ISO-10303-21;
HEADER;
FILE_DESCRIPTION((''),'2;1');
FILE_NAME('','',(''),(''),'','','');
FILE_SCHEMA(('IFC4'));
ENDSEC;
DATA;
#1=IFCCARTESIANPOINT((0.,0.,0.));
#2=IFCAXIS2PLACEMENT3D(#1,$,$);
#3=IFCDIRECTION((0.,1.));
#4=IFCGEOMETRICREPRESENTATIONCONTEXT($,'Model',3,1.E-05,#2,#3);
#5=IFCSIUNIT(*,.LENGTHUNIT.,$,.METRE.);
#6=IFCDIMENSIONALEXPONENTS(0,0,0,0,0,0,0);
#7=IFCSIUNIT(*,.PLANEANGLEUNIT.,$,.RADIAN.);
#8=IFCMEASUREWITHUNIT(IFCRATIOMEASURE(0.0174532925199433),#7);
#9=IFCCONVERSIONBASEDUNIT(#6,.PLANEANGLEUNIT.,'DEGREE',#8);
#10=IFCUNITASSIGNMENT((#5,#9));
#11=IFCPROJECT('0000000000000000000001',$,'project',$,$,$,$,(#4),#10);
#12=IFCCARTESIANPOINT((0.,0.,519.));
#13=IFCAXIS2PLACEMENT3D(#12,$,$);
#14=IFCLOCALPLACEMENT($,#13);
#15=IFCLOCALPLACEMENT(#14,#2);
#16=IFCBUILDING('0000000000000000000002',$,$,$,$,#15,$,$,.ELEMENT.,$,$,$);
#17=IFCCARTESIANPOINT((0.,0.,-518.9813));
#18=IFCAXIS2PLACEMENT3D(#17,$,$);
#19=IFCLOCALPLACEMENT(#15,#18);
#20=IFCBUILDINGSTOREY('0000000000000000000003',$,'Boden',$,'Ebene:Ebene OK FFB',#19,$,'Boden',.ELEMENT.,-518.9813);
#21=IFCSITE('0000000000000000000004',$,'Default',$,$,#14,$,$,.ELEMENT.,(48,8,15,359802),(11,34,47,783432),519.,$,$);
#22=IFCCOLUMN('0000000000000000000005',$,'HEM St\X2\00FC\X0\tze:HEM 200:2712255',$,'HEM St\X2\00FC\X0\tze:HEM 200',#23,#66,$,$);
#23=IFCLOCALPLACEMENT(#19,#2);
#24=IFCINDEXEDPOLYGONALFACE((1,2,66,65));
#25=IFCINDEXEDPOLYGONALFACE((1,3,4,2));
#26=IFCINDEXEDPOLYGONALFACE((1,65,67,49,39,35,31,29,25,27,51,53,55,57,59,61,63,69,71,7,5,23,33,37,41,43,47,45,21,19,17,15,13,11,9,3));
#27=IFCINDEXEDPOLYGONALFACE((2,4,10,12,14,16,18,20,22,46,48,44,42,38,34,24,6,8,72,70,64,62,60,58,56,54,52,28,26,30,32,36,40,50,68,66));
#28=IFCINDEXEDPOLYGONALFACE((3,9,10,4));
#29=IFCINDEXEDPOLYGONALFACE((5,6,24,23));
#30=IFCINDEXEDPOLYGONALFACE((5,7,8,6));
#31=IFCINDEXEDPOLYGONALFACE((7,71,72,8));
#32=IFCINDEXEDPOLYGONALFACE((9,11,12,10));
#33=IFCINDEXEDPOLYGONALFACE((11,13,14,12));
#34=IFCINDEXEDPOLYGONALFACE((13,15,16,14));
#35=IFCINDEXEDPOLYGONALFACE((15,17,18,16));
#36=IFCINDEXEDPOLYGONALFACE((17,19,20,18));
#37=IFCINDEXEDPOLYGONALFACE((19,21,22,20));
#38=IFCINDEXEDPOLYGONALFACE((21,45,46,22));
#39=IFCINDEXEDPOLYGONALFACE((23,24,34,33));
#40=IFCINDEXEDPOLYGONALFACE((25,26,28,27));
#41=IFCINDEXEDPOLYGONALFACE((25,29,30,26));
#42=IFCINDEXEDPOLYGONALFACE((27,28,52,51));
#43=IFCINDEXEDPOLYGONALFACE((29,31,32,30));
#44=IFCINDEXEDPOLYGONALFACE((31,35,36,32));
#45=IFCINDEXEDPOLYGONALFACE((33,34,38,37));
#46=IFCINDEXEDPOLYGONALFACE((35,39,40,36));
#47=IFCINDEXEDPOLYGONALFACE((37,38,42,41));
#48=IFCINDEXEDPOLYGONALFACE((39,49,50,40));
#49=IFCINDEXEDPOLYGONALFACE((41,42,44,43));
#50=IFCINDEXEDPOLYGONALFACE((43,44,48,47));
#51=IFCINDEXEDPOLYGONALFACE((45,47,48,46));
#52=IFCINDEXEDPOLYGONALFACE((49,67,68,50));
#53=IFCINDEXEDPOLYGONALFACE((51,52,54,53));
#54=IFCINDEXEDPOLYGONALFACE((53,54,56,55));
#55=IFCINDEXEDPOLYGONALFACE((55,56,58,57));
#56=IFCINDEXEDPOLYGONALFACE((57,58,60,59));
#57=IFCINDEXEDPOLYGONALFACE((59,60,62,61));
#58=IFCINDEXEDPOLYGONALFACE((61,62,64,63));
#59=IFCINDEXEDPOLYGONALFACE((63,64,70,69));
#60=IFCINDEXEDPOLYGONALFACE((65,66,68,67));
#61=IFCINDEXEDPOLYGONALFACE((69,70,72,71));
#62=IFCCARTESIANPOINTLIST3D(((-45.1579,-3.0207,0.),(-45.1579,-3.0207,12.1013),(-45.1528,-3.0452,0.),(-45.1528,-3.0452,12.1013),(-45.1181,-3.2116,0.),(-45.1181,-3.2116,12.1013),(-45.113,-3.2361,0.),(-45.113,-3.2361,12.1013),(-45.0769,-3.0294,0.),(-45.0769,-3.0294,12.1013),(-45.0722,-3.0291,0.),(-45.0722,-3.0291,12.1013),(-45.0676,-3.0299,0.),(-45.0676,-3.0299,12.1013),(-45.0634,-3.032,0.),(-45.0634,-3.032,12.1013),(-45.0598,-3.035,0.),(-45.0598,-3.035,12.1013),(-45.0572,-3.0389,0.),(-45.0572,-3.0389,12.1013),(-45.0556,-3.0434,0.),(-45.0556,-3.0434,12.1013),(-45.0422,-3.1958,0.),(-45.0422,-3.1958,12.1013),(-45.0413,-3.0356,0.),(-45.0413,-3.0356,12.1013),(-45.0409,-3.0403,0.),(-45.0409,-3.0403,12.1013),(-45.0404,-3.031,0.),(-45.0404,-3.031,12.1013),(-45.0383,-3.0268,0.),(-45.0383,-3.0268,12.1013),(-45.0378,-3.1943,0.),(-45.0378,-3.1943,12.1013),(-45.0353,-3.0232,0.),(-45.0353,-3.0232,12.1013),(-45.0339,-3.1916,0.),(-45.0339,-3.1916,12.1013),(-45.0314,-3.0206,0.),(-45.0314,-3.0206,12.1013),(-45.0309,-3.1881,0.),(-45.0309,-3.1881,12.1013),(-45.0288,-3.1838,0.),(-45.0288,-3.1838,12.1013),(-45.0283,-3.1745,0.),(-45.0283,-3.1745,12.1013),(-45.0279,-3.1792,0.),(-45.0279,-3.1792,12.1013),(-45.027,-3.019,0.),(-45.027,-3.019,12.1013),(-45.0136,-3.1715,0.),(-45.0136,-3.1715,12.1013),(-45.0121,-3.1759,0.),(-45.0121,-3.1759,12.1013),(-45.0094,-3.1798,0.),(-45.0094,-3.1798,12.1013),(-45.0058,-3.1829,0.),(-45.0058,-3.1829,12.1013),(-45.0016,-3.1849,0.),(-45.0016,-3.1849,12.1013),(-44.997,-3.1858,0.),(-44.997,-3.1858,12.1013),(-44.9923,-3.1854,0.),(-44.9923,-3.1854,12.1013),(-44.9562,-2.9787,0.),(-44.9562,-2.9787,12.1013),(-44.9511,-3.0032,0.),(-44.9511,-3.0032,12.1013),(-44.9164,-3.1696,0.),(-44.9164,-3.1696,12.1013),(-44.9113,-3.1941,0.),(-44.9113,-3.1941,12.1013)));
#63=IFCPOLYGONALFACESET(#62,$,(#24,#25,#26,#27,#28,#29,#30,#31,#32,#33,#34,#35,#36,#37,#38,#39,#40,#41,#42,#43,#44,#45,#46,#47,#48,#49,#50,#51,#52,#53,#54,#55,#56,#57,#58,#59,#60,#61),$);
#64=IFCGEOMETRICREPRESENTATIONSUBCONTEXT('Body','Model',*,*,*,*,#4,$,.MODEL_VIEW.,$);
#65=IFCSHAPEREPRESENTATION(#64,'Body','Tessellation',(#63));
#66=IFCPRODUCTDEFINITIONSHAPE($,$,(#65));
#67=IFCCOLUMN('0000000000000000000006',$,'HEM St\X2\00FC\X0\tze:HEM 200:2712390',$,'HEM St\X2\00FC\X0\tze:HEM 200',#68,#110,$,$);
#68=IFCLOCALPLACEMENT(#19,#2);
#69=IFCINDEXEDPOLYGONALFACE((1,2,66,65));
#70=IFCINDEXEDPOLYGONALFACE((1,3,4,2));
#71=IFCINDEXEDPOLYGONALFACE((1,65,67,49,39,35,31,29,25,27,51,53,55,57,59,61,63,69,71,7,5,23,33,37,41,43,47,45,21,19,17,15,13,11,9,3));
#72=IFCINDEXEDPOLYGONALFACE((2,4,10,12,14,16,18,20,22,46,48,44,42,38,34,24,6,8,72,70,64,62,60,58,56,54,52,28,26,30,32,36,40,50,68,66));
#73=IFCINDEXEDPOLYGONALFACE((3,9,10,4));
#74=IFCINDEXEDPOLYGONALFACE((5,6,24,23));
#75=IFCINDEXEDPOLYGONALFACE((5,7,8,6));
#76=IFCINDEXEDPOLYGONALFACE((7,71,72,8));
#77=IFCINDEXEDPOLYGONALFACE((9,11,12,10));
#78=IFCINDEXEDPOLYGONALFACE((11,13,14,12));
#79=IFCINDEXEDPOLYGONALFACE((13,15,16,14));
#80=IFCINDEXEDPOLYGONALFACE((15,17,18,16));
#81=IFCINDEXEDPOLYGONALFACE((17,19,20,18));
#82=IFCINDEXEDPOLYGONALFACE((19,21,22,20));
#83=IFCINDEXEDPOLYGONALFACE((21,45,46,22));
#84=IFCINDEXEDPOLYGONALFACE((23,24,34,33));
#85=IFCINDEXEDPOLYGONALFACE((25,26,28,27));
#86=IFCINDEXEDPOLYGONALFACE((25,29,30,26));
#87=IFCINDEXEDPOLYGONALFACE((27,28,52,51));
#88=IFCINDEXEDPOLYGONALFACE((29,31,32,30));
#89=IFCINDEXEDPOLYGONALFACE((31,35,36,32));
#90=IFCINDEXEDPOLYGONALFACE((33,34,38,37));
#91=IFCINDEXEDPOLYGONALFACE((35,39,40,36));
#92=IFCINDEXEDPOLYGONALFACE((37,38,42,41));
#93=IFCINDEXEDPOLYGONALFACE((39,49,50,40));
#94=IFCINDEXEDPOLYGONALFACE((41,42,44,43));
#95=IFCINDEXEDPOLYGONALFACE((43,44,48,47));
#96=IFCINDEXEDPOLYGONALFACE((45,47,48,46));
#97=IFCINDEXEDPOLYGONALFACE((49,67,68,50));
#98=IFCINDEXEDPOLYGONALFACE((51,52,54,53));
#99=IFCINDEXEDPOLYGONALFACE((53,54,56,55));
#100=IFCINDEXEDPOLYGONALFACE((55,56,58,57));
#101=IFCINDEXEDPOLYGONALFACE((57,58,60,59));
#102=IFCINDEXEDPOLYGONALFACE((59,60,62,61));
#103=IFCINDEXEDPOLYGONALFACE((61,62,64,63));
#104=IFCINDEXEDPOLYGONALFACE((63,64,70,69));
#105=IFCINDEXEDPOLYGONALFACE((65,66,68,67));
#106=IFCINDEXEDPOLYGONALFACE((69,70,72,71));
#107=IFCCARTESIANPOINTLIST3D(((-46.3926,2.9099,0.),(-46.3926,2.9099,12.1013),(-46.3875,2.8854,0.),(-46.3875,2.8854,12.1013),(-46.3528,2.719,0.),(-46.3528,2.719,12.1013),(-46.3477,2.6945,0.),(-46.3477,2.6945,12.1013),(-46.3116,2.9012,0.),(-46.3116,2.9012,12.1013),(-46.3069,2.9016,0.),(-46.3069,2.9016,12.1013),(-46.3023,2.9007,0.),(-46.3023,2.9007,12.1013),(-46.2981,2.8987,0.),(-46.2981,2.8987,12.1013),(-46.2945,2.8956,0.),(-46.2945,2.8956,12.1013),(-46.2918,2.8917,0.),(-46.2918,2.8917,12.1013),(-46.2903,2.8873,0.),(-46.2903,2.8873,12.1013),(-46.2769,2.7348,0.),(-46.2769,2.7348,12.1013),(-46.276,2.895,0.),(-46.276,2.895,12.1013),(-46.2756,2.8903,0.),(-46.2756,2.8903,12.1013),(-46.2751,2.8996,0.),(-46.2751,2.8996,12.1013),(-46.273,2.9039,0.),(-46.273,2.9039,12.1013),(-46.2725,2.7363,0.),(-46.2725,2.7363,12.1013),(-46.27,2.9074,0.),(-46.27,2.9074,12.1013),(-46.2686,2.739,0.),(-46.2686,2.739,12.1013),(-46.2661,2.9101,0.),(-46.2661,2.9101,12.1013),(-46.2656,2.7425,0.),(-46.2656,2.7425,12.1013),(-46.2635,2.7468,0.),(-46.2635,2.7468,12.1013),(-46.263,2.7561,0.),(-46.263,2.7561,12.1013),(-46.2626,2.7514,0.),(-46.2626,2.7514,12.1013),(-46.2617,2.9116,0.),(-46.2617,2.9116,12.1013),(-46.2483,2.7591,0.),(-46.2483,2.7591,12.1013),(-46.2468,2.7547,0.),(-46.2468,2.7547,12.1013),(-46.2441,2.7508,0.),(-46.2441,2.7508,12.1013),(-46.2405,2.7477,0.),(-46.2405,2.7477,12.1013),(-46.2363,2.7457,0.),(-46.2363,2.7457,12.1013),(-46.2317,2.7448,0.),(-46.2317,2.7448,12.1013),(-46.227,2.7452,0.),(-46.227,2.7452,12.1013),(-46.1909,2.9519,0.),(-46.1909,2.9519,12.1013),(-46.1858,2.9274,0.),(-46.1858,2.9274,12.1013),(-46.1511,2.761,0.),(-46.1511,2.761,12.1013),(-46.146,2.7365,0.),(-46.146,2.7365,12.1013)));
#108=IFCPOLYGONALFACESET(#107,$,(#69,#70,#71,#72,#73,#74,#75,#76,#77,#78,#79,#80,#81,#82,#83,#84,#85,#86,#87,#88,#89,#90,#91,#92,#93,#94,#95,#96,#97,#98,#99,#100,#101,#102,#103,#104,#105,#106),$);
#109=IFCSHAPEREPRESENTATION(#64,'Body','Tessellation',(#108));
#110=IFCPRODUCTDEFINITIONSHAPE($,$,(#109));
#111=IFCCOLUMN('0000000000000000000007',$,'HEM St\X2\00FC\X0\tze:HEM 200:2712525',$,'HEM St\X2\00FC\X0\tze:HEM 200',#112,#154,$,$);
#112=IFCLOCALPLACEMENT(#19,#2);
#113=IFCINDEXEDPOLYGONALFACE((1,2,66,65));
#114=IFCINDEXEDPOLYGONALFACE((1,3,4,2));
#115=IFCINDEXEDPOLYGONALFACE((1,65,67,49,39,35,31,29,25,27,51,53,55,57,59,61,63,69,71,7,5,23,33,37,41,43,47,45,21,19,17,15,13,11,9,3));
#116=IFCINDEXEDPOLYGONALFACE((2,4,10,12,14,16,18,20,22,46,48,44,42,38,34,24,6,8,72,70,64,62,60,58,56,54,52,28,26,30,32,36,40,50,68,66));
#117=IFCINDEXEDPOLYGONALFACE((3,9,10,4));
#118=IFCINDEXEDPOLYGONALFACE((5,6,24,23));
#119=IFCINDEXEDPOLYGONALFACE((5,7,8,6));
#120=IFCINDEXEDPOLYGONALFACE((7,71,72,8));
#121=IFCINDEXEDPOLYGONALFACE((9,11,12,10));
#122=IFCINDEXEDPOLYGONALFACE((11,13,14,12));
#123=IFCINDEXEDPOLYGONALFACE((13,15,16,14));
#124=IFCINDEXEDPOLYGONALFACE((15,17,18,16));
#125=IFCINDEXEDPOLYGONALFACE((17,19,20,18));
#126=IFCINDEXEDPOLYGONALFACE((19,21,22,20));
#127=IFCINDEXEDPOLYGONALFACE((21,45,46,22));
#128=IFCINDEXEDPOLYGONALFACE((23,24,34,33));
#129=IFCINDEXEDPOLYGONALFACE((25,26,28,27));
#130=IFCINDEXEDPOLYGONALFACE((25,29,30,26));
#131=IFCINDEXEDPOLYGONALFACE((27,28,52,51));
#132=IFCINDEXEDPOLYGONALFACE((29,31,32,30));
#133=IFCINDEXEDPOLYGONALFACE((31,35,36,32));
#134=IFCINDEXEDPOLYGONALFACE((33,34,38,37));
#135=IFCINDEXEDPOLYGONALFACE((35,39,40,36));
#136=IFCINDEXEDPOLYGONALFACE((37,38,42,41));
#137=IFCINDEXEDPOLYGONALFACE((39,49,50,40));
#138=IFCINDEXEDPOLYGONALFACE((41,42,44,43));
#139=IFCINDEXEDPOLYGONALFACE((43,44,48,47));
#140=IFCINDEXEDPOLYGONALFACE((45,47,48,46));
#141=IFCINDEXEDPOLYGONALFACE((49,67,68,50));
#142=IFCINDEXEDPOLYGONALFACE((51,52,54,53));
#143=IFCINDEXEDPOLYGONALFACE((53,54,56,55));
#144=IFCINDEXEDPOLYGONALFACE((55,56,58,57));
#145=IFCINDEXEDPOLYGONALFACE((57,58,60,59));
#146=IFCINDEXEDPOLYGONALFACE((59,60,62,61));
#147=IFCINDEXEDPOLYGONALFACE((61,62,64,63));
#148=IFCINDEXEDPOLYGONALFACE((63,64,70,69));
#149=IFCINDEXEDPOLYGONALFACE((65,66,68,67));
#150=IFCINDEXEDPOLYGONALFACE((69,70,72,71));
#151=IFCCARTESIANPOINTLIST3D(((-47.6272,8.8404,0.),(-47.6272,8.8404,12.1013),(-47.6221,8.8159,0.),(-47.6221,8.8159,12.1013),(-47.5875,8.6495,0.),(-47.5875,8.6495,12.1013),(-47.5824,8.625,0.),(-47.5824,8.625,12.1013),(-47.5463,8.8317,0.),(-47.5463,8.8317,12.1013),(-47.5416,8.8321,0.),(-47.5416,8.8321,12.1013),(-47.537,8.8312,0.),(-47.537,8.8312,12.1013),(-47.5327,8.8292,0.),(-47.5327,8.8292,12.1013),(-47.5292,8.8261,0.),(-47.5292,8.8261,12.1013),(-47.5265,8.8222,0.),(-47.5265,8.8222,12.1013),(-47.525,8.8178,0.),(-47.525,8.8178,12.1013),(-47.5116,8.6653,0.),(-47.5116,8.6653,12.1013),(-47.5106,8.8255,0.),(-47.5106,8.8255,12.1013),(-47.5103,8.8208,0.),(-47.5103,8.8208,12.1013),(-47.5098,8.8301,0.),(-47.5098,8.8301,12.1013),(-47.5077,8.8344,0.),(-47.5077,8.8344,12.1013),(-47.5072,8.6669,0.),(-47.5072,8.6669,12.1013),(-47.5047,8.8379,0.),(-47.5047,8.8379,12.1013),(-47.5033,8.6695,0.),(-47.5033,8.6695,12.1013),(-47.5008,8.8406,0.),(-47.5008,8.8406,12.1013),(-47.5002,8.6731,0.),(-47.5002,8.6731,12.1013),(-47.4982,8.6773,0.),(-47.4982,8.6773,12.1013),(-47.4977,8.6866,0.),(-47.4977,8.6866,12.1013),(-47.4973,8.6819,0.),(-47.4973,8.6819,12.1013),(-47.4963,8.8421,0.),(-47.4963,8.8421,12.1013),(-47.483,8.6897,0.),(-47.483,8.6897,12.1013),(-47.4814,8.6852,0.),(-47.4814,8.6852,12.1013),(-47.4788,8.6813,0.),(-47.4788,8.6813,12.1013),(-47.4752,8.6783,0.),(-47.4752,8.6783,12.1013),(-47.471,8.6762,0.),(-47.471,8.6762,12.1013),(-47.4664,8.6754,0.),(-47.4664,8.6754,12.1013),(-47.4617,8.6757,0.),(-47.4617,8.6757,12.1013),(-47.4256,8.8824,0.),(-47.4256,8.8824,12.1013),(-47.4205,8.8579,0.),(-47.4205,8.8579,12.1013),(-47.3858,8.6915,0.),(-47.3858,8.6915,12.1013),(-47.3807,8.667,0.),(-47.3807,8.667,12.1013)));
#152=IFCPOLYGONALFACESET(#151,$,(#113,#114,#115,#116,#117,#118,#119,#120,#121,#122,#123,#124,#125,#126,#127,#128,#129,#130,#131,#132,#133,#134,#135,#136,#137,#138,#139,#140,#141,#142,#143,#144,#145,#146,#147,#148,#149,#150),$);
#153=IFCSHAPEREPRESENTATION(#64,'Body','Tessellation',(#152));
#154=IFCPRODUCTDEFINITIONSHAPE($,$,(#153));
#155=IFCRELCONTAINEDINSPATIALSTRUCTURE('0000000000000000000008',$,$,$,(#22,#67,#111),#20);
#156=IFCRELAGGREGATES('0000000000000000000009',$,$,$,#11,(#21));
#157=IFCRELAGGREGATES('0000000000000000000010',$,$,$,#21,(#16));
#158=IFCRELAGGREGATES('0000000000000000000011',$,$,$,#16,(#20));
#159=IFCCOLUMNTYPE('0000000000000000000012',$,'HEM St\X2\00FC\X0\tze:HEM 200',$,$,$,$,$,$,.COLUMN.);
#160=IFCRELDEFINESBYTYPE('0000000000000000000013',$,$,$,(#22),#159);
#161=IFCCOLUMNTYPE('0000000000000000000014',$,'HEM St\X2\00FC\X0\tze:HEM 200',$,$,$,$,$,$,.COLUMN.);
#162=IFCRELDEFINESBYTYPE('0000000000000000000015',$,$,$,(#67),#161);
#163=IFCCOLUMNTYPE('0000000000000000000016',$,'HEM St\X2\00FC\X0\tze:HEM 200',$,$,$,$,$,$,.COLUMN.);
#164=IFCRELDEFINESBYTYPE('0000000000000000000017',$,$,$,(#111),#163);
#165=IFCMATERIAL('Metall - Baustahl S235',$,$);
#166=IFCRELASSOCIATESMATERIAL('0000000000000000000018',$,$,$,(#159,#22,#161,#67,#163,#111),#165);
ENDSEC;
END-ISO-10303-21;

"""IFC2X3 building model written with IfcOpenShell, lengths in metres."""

from ifc_helpers import new_model, entity, si_unit, converted_unit, direction, frame, frame_2d, origin, place, context, subcontext, project, spatial, polyline, circle_curve, parameter, trimmed, segment, composite_curve, outline, extrude, source, transform, mapped, material, type_object, type_shapes, element, save


model = new_model("IFC2X3")

# Units and contexts
model_context = context("Model", 3, precision=1e-05, world=origin(), true_north=direction((0.0, 1.0)))
body_context = subcontext(model_context, "Body", "Model", "MODEL_VIEW")
ifc_project = project(units=[si_unit("LENGTHUNIT", "METRE"), converted_unit("PLANEANGLEUNIT", "DEGREE", entity("IfcRatioMeasure", 0.0174532925199433), si_unit("PLANEANGLEUNIT", "RADIAN"), dimensions=[0, 0, 0, 0, 0, 0, 0])], contexts=[model_context])

# Site, building, storey
site_placement = place(None, frame((0.0, 0.0, 519.0)))
site = spatial("IfcSite", under=ifc_project, at=site_placement, Name="Default", CompositionType="ELEMENT", RefLatitude=(48, 8, 15, 359802), RefLongitude=(11, 34, 47, 783432), RefElevation=519.0)
building_placement = place(site_placement, origin())
building = spatial("IfcBuilding", under=site, at=building_placement, CompositionType="ELEMENT")
storey_placement = place(building_placement, frame((0.0, 0.0, -518.9813)))
storey = spatial("IfcBuildingStorey", under=building, at=storey_placement, Name="Boden", ObjectType="Ebene:Ebene OK FFB", LongName="Boden", CompositionType="ELEMENT", Elevation=-518.9813)

# Columns
ifc_material_1 = material(Name="Metall - Baustahl S235")
column_type_1 = type_object("IfcColumnType", Name="HEM Stütze:HEM 200", PredefinedType="COLUMN", material=ifc_material_1)
shared_shape_1 = source(origin(), body_context, "Body", "SweptSolid", [
    extrude(outline(composite_curve([segment(polyline([(0.085, -0.103), (0.11, -0.103)]), True, "CONTINUOUS"), segment(polyline([(0.11, -0.103), (0.11, 0.103)]), True, "CONTINUOUS"), segment(polyline([(0.11, 0.103), (0.085, 0.103)]), True, "CONTINUOUS"), segment(polyline([(0.085, 0.103), (0.085, 0.0255)]), True, "CONTINUOUS"), segment(trimmed(circle_curve(frame_2d((0.067, 0.0255), x_axis=(1.0, 0.0)), 0.018), [parameter(270.0)], [parameter(0.0)], True, "PARAMETER"), False, "CONTINUOUS"), segment(polyline([(0.067, 0.0075), (-0.067, 0.0075)]), True, "CONTINUOUS"), segment(trimmed(circle_curve(frame_2d((-0.067, 0.0255), x_axis=(0.0, -1.0)), 0.018), [parameter(270.0)], [parameter(0.0)], True, "PARAMETER"), False, "CONTINUOUS"), segment(polyline([(-0.085, 0.0255), (-0.085, 0.103)]), True, "CONTINUOUS"), segment(polyline([(-0.085, 0.103), (-0.11, 0.103)]), True, "CONTINUOUS"), segment(polyline([(-0.11, 0.103), (-0.11, -0.103)]), True, "CONTINUOUS"), segment(polyline([(-0.11, -0.103), (-0.085, -0.103)]), True, "CONTINUOUS"), segment(polyline([(-0.085, -0.103), (-0.085, -0.0255)]), True, "CONTINUOUS"), segment(trimmed(circle_curve(frame_2d((-0.067, -0.0255), x_axis=(-1.0, 0.0)), 0.018), [parameter(270.0)], [parameter(0.0)], True, "PARAMETER"), False, "CONTINUOUS"), segment(polyline([(-0.067, -0.0075), (0.067, -0.0075)]), True, "CONTINUOUS"), segment(trimmed(circle_curve(frame_2d((0.067, -0.0255), x_axis=(0.0, 1.0)), 0.018), [parameter(270.0)], [parameter(0.0)], True, "PARAMETER"), False, "CONTINUOUS"), segment(polyline([(0.085, -0.0255), (0.085, -0.103)]), True, "CONTINUOUS")], self_intersect=False)), frame((-45.0346, -3.1074, -518.9813), z_axis=(0.0, 0.0, 1.0), x_axis=(-0.20382, 0.979008, 0.0)), (0.0, 0.0, 1.0), 12.1013),
])
type_shapes(column_type_1, [shared_shape_1])
column_1_placement = place(storey_placement, frame((0.0, 0.0, 518.9813)))
element("IfcColumn", 1, at=column_1_placement, inside=storey, type_object=column_type_1, material=ifc_material_1, Name="HEM Stütze:HEM 200:2712255", ObjectType="HEM Stütze:HEM 200", context=body_context, shape_type="MappedRepresentation", body=[
    mapped(shared_shape_1, transform((0.0, 0.0, 0.0), scale=1.0)),
])
column_type_2 = type_object("IfcColumnType", Name="HEM Stütze:HEM 200", PredefinedType="COLUMN", material=ifc_material_1)
shared_shape_2 = source(origin(), body_context, "Body", "SweptSolid", [
    extrude(outline(composite_curve([segment(polyline([(0.085, -0.103), (0.11, -0.103)]), True, "CONTINUOUS"), segment(polyline([(0.11, -0.103), (0.11, 0.103)]), True, "CONTINUOUS"), segment(polyline([(0.11, 0.103), (0.085, 0.103)]), True, "CONTINUOUS"), segment(polyline([(0.085, 0.103), (0.085, 0.0255)]), True, "CONTINUOUS"), segment(trimmed(circle_curve(frame_2d((0.067, 0.0255), x_axis=(1.0, 0.0)), 0.018), [parameter(270.0)], [parameter(0.0)], True, "PARAMETER"), False, "CONTINUOUS"), segment(polyline([(0.067, 0.0075), (-0.067, 0.0075)]), True, "CONTINUOUS"), segment(trimmed(circle_curve(frame_2d((-0.067, 0.0255), x_axis=(0.0, -1.0)), 0.018), [parameter(270.0)], [parameter(0.0)], True, "PARAMETER"), False, "CONTINUOUS"), segment(polyline([(-0.085, 0.0255), (-0.085, 0.103)]), True, "CONTINUOUS"), segment(polyline([(-0.085, 0.103), (-0.11, 0.103)]), True, "CONTINUOUS"), segment(polyline([(-0.11, 0.103), (-0.11, -0.103)]), True, "CONTINUOUS"), segment(polyline([(-0.11, -0.103), (-0.085, -0.103)]), True, "CONTINUOUS"), segment(polyline([(-0.085, -0.103), (-0.085, -0.0255)]), True, "CONTINUOUS"), segment(trimmed(circle_curve(frame_2d((-0.067, -0.0255), x_axis=(-1.0, 0.0)), 0.018), [parameter(270.0)], [parameter(0.0)], True, "PARAMETER"), False, "CONTINUOUS"), segment(polyline([(-0.067, -0.0075), (0.067, -0.0075)]), True, "CONTINUOUS"), segment(trimmed(circle_curve(frame_2d((0.067, -0.0255), x_axis=(0.0, 1.0)), 0.018), [parameter(270.0)], [parameter(0.0)], True, "PARAMETER"), False, "CONTINUOUS"), segment(polyline([(0.085, -0.0255), (0.085, -0.103)]), True, "CONTINUOUS")], self_intersect=False)), frame((-46.2693, 2.8232, -518.9813), z_axis=(0.0, 0.0, 1.0), x_axis=(-0.20382, 0.979008, 0.0)), (0.0, 0.0, 1.0), 12.1013),
])
type_shapes(column_type_2, [shared_shape_2])
column_2_placement = place(storey_placement, frame((0.0, 0.0, 518.9813)))
element("IfcColumn", 2, at=column_2_placement, inside=storey, type_object=column_type_2, material=ifc_material_1, Name="HEM Stütze:HEM 200:2712390", ObjectType="HEM Stütze:HEM 200", context=body_context, shape_type="MappedRepresentation", body=[
    mapped(shared_shape_2, transform((0.0, 0.0, 0.0), scale=1.0)),
])
column_type_3 = type_object("IfcColumnType", Name="HEM Stütze:HEM 200", PredefinedType="COLUMN", material=ifc_material_1)
shared_shape_3 = source(origin(), body_context, "Body", "SweptSolid", [
    extrude(outline(composite_curve([segment(polyline([(0.085, -0.103), (0.11, -0.103)]), True, "CONTINUOUS"), segment(polyline([(0.11, -0.103), (0.11, 0.103)]), True, "CONTINUOUS"), segment(polyline([(0.11, 0.103), (0.085, 0.103)]), True, "CONTINUOUS"), segment(polyline([(0.085, 0.103), (0.085, 0.0255)]), True, "CONTINUOUS"), segment(trimmed(circle_curve(frame_2d((0.067, 0.0255), x_axis=(1.0, 0.0)), 0.018), [parameter(270.0)], [parameter(0.0)], True, "PARAMETER"), False, "CONTINUOUS"), segment(polyline([(0.067, 0.0075), (-0.067, 0.0075)]), True, "CONTINUOUS"), segment(trimmed(circle_curve(frame_2d((-0.067, 0.0255), x_axis=(0.0, -1.0)), 0.018), [parameter(270.0)], [parameter(0.0)], True, "PARAMETER"), False, "CONTINUOUS"), segment(polyline([(-0.085, 0.0255), (-0.085, 0.103)]), True, "CONTINUOUS"), segment(polyline([(-0.085, 0.103), (-0.11, 0.103)]), True, "CONTINUOUS"), segment(polyline([(-0.11, 0.103), (-0.11, -0.103)]), True, "CONTINUOUS"), segment(polyline([(-0.11, -0.103), (-0.085, -0.103)]), True, "CONTINUOUS"), segment(polyline([(-0.085, -0.103), (-0.085, -0.0255)]), True, "CONTINUOUS"), segment(trimmed(circle_curve(frame_2d((-0.067, -0.0255), x_axis=(-1.0, 0.0)), 0.018), [parameter(270.0)], [parameter(0.0)], True, "PARAMETER"), False, "CONTINUOUS"), segment(polyline([(-0.067, -0.0075), (0.067, -0.0075)]), True, "CONTINUOUS"), segment(trimmed(circle_curve(frame_2d((0.067, -0.0255), x_axis=(0.0, 1.0)), 0.018), [parameter(270.0)], [parameter(0.0)], True, "PARAMETER"), False, "CONTINUOUS"), segment(polyline([(0.085, -0.0255), (0.085, -0.103)]), True, "CONTINUOUS")], self_intersect=False)), frame((-47.504, 8.7537, -518.9813), z_axis=(0.0, 0.0, 1.0), x_axis=(-0.20382, 0.979008, 0.0)), (0.0, 0.0, 1.0), 12.1013),
])
type_shapes(column_type_3, [shared_shape_3])
column_3_placement = place(storey_placement, frame((0.0, 0.0, 518.9813)))
element("IfcColumn", 3, at=column_3_placement, inside=storey, type_object=column_type_3, material=ifc_material_1, Name="HEM Stütze:HEM 200:2712525", ObjectType="HEM Stütze:HEM 200", context=body_context, shape_type="MappedRepresentation", body=[
    mapped(shared_shape_3, transform((0.0, 0.0, 0.0), scale=1.0)),
])

save(model, "model.ifc")
